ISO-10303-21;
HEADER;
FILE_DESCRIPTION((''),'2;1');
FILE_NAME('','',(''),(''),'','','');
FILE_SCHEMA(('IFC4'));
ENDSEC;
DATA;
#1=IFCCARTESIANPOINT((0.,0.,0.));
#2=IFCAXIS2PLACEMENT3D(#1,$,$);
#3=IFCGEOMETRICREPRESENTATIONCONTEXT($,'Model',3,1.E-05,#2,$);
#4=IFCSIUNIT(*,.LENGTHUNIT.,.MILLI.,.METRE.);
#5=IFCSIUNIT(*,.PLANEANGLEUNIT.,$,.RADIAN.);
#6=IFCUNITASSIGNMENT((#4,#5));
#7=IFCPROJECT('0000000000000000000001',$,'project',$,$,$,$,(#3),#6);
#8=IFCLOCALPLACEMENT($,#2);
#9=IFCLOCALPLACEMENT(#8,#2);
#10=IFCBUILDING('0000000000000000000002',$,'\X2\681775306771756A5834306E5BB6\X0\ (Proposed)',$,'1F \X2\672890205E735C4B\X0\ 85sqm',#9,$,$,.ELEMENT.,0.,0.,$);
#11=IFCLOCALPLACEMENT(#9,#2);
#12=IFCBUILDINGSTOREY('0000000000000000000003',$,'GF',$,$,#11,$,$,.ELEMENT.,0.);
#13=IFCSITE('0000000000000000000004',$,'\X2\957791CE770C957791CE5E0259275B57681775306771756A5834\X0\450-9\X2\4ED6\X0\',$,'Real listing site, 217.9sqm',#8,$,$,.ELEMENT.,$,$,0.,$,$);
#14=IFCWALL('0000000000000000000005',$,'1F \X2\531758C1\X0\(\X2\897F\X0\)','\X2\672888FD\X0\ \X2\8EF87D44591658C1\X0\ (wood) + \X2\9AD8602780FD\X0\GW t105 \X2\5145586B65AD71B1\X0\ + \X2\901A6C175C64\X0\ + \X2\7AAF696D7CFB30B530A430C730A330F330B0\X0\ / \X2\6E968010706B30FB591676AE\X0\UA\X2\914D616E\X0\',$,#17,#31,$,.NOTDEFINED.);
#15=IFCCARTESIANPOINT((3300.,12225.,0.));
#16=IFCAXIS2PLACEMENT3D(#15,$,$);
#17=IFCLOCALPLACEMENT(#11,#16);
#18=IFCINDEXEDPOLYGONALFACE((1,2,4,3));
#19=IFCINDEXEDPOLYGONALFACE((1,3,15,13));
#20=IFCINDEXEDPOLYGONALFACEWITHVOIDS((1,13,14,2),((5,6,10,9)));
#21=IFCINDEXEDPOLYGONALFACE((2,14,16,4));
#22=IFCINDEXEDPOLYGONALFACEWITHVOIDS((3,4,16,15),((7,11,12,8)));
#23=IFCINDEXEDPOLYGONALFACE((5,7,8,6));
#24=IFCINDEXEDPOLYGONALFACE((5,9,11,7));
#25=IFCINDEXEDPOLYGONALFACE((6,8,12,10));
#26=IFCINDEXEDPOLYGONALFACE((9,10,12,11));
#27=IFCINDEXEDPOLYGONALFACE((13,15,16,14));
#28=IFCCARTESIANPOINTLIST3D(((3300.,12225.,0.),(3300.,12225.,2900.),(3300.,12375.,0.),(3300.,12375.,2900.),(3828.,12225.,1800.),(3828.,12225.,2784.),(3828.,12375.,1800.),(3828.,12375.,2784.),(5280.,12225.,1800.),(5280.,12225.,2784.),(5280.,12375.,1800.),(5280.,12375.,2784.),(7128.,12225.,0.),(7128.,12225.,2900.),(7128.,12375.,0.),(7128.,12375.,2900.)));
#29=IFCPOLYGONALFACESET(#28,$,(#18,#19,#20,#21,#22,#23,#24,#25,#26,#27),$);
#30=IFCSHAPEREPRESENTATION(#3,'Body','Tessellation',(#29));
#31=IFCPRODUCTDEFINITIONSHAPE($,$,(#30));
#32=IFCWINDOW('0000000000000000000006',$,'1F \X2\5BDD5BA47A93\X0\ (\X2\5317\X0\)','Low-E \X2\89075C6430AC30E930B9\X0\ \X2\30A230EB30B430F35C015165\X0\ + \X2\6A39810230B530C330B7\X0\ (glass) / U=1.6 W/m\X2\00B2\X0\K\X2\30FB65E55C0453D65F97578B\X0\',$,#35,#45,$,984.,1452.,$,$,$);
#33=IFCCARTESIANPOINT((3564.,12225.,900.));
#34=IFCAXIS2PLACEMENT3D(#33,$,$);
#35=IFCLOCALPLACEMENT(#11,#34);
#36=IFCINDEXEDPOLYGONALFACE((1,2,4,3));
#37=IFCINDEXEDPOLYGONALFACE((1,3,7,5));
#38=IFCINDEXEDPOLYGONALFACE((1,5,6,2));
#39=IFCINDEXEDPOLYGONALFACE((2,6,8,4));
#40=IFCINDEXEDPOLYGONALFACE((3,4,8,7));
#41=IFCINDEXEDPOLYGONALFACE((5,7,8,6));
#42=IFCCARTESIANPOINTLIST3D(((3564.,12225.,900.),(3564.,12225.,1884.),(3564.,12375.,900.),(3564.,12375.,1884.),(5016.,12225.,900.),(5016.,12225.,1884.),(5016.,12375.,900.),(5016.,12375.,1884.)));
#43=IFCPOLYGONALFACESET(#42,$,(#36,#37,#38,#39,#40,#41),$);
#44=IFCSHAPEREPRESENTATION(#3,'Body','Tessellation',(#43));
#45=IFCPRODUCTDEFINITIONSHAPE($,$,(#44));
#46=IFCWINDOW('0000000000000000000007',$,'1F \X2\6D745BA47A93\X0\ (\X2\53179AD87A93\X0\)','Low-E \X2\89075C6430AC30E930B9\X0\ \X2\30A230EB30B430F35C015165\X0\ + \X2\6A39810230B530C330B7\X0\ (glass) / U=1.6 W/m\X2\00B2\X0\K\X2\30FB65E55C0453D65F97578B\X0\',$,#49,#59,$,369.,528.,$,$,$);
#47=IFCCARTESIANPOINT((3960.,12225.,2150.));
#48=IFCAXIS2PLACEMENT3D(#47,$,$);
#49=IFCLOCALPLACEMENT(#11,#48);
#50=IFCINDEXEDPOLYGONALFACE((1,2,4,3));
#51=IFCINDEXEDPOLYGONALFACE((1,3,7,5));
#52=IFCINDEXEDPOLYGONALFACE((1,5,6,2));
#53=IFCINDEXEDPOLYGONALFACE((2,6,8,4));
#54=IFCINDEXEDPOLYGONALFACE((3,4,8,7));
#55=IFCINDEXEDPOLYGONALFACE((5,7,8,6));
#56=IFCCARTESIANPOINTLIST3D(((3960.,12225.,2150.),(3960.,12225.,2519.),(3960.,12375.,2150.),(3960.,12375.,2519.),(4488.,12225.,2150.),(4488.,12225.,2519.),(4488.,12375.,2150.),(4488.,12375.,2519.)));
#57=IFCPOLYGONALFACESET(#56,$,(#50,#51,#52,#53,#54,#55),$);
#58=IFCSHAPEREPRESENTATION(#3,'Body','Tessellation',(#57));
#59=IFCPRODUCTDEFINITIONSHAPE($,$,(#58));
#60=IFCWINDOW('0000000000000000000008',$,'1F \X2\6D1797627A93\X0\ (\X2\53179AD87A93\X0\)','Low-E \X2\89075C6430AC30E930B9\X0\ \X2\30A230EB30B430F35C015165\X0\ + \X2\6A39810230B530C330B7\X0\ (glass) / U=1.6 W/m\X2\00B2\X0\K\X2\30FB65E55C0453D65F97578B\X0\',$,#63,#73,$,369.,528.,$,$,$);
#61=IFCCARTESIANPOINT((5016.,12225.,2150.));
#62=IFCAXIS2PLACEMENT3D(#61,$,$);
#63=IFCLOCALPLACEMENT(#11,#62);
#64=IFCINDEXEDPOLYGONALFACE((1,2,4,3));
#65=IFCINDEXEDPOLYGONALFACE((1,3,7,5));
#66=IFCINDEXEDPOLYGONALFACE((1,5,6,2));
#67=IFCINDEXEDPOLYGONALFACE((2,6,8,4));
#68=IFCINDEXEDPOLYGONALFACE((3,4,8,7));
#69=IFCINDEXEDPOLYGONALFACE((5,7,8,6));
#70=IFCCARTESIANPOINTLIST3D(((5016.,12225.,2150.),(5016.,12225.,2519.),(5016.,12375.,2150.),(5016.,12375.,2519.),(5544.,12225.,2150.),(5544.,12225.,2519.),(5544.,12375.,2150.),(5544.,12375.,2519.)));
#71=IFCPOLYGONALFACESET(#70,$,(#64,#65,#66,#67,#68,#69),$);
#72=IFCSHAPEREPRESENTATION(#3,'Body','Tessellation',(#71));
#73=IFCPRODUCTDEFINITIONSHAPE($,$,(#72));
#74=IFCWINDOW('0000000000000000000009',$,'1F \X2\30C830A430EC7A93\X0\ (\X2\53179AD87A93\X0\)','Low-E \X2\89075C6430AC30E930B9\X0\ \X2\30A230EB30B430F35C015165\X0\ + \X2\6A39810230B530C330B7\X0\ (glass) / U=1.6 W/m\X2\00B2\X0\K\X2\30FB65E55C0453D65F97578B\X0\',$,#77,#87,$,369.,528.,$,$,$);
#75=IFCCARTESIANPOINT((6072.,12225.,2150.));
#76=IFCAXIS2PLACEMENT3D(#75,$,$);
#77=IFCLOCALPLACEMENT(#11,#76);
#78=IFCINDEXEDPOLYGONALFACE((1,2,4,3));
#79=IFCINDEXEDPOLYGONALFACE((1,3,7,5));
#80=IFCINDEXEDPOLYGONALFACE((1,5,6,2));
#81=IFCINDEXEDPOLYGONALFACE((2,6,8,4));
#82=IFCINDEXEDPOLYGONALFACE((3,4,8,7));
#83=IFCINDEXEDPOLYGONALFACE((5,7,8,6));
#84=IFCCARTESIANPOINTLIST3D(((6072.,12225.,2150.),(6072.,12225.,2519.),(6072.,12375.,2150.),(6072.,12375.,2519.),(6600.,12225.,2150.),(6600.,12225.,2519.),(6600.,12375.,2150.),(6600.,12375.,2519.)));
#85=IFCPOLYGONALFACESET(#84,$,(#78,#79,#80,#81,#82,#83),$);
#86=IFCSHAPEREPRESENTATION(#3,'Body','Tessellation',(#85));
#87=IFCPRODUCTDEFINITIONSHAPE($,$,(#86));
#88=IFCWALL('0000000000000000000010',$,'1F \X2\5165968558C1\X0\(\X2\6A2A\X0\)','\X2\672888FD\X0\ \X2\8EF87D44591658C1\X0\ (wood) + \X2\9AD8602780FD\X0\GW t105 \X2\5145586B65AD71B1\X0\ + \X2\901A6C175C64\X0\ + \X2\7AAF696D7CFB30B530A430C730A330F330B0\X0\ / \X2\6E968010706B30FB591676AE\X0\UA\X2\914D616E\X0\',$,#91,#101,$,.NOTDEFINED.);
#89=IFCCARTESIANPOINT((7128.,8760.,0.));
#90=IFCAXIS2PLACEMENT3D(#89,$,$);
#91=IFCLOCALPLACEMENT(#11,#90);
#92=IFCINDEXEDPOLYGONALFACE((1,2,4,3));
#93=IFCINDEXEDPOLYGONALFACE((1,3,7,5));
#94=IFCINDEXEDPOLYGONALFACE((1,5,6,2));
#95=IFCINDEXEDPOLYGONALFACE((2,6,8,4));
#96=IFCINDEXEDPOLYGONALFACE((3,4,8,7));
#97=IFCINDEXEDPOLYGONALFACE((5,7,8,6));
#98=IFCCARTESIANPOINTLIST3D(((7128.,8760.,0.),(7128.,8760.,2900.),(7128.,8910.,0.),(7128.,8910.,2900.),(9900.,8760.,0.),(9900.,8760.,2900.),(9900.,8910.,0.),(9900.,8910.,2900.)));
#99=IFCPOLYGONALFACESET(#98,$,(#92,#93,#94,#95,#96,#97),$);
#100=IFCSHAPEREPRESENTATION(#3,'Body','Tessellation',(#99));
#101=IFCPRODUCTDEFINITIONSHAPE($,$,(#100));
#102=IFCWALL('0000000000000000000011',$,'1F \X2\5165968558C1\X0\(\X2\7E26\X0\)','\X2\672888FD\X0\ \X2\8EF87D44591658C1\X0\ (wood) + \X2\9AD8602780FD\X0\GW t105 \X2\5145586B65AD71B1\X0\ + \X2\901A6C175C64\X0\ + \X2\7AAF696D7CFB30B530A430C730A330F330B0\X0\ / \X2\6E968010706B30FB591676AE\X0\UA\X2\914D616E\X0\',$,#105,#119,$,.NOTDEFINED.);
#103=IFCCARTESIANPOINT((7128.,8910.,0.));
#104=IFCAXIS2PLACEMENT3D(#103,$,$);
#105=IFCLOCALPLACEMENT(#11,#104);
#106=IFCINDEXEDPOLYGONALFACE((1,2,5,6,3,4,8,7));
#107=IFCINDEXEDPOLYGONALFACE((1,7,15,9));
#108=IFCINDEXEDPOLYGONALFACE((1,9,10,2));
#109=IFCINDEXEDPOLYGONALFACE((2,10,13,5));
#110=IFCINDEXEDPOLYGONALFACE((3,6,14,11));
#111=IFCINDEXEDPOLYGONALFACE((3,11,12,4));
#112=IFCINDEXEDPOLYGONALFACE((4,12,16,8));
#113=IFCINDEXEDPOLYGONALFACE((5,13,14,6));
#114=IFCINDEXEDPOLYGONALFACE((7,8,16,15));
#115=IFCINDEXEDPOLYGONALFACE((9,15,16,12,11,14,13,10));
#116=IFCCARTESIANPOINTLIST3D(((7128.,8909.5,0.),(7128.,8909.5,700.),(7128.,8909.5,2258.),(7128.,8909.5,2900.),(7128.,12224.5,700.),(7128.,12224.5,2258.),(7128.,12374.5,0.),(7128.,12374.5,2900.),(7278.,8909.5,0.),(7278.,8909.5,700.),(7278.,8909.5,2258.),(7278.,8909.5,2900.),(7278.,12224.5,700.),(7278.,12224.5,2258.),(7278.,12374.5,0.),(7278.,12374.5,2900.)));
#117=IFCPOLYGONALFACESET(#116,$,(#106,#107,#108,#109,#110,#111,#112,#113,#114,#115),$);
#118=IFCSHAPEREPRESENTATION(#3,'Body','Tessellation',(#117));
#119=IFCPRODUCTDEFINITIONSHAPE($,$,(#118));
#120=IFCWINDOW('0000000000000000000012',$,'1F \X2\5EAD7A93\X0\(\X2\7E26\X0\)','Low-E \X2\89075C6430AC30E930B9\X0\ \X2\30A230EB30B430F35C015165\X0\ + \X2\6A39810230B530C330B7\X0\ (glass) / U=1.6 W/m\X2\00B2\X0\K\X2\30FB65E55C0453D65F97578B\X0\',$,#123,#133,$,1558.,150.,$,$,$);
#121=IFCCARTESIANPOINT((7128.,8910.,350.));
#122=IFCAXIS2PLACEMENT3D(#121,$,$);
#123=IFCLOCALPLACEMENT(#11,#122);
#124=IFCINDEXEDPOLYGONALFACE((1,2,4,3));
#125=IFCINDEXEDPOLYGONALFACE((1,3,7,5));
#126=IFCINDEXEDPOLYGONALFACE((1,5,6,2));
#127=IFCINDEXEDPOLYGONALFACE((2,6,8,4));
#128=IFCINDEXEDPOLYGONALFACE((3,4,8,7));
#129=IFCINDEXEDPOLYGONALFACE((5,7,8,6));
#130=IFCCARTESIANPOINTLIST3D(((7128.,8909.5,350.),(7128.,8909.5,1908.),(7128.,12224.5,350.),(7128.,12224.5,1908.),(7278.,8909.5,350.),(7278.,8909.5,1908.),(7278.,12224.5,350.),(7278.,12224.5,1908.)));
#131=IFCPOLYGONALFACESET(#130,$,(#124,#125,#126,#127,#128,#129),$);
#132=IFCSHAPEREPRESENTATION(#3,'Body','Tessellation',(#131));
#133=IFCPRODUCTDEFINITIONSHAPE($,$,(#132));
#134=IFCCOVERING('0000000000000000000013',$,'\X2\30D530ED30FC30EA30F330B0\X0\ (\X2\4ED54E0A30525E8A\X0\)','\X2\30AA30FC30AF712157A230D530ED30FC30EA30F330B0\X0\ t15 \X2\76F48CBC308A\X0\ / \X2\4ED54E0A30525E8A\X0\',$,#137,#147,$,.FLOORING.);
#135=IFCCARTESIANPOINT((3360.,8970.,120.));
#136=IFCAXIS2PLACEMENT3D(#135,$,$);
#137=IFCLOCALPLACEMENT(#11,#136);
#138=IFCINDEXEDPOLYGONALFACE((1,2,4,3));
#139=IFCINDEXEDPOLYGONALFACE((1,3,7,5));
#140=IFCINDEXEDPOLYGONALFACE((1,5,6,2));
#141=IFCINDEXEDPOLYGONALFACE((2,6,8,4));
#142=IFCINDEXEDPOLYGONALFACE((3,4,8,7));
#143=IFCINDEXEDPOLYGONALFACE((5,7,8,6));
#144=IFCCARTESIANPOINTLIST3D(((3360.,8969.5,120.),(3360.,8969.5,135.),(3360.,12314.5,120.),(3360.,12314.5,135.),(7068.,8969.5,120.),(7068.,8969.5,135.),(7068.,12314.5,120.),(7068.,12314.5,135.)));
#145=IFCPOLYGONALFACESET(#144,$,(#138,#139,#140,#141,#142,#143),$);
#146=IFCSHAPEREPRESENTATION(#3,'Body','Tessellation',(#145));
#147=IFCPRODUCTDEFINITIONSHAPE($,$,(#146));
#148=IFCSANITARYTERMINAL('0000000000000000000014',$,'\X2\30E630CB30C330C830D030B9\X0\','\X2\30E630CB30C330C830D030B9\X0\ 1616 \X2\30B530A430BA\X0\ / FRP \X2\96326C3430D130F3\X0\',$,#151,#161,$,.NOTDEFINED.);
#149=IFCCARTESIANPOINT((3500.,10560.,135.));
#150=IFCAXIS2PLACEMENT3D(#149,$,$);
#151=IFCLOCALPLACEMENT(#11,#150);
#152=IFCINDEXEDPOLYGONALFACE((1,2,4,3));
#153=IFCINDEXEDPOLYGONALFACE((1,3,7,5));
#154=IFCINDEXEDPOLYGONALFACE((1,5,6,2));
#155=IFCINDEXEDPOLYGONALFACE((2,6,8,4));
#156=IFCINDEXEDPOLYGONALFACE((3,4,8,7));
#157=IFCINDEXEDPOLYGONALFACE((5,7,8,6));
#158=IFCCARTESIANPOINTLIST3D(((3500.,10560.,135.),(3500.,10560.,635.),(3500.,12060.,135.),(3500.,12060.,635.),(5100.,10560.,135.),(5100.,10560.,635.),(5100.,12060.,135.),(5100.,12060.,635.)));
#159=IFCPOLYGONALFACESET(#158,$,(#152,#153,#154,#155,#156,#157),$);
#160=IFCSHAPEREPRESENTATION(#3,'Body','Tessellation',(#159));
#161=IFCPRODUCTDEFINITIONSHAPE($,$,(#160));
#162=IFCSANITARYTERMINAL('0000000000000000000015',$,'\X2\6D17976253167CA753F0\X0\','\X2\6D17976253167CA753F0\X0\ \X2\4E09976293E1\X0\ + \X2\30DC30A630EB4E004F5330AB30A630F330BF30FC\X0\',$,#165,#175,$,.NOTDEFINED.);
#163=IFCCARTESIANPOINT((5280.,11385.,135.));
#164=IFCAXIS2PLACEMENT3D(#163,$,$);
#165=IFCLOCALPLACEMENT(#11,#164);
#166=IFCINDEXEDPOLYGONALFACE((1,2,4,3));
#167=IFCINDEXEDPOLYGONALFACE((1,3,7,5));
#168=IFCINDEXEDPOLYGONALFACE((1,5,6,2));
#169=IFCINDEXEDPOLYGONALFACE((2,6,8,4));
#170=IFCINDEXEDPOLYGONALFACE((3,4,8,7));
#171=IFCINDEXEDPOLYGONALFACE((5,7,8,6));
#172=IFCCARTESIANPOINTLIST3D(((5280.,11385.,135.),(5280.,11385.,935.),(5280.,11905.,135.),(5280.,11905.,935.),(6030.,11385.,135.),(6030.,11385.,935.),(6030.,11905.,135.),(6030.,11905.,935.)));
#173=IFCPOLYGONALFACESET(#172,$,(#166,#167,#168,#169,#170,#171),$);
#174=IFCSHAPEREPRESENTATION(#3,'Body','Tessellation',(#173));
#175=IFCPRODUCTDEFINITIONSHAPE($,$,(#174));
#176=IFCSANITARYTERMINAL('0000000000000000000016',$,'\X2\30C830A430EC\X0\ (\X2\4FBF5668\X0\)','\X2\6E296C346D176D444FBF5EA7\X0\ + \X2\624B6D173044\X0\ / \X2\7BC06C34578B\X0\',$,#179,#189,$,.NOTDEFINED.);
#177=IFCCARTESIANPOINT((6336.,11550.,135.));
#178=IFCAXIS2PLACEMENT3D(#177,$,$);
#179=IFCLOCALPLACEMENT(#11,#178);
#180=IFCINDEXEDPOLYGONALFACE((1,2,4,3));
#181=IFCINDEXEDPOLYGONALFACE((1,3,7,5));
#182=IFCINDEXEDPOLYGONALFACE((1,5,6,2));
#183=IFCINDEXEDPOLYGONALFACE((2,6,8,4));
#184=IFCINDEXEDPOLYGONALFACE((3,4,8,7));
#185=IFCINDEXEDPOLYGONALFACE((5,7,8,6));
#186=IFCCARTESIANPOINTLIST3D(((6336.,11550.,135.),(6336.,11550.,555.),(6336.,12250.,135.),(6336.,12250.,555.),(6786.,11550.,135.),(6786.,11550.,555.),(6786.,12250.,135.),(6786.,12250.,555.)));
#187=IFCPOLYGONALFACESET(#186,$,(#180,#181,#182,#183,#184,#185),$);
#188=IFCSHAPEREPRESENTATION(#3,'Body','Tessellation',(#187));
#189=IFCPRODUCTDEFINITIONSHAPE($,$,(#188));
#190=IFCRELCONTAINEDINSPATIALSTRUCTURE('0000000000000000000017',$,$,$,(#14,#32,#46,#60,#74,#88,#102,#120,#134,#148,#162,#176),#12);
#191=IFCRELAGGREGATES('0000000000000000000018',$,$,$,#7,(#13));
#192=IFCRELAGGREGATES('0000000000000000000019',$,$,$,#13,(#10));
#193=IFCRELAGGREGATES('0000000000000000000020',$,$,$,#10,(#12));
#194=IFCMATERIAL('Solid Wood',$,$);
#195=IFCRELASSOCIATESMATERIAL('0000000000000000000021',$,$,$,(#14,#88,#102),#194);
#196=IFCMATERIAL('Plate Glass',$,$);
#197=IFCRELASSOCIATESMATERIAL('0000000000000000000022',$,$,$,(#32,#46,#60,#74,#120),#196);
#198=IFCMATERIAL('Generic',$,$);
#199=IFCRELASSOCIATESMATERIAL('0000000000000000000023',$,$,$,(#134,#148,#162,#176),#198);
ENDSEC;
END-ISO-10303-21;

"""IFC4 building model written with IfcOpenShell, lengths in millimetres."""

from ifc_helpers import new_model, si_unit, frame, frame_2d, origin, place, context, project, spatial, rectangle, extrude, material, element, fill, save


model = new_model("IFC4")

# Units and contexts
model_context = context("Model", 3, precision=1e-05, world=origin())
ifc_project = project(units=[si_unit("LENGTHUNIT", "METRE", prefix="MILLI"), si_unit("PLANEANGLEUNIT", "RADIAN")], contexts=[model_context])

# Site, building, storey
site_placement = place(None, origin())
site = spatial("IfcSite", under=ifc_project, at=site_placement, Name="長野県長野市大字栗田東番場450-9他", ObjectType="Real listing site, 217.9sqm", CompositionType="ELEMENT", RefElevation=0.0)
building_placement = place(site_placement, origin())
building = spatial("IfcBuilding", under=site, at=building_placement, Name="栗田東番場の家 (Proposed)", ObjectType="1F 木造平屋 85sqm", CompositionType="ELEMENT", ElevationOfRefHeight=0.0, ElevationOfTerrain=0.0)
storey_placement = place(building_placement, origin())
storey = spatial("IfcBuildingStorey", under=building, at=storey_placement, Name="GF", CompositionType="ELEMENT", Elevation=0.0)

# Shared definitions
ifc_material_1 = material(Name="Solid Wood")

# Wall, openings, windows
wall_1_placement = place(storey_placement, frame((3300.0, 12225.0, 0.0)))
wall_1 = element("IfcWall", 1, at=wall_1_placement, inside=storey, material=ifc_material_1, Name="1F 北壁(西)", Description="木製 軸組外壁 (wood) + 高性能GW t105 充填断熱 + 通気層 + 窯業系サイディング / 準耐火・外皮UA配慮", PredefinedType="NOTDEFINED", context=model_context, shape_type="SweptSolid", body=[
    extrude(rectangle(XDim=3828.0, YDim=150.0, at=frame_2d((1914.0, 75.0))), frame((3300.0, 12225.0, 0.0)), (0.0, 0.0, 1.0), 2900.0),
])
opening_1_placement = place(storey_placement, frame((3564.0, 12225.0, 900.0)))
opening_1 = element("IfcOpeningElement", 2, at=opening_1_placement, cuts=wall_1, PredefinedType="NOTDEFINED", context=model_context, shape_type="SweptSolid", body=[
    extrude(rectangle(XDim=1452.0, YDim=150.0, at=frame_2d((726.0, 75.0))), frame((3564.0, 12225.0, 900.0)), (0.0, 0.0, 1.0), 984.0),
])
opening_2_placement = place(storey_placement, frame((3960.0, 12225.0, 2150.0)))
opening_2 = element("IfcOpeningElement", 3, at=opening_2_placement, cuts=wall_1, PredefinedType="NOTDEFINED", context=model_context, shape_type="SweptSolid", body=[
    extrude(rectangle(XDim=528.0, YDim=150.0, at=frame_2d((264.0, 75.0))), frame((3960.0, 12225.0, 2150.0)), (0.0, 0.0, 1.0), 369.0),
])
opening_3_placement = place(storey_placement, frame((5016.0, 12225.0, 2150.0)))
opening_3 = element("IfcOpeningElement", 4, at=opening_3_placement, cuts=wall_1, PredefinedType="NOTDEFINED", context=model_context, shape_type="SweptSolid", body=[
    extrude(rectangle(XDim=528.0, YDim=150.0, at=frame_2d((264.0, 75.0))), frame((5016.0, 12225.0, 2150.0)), (0.0, 0.0, 1.0), 369.0),
])
opening_4_placement = place(storey_placement, frame((6072.0, 12225.0, 2150.0)))
opening_4 = element("IfcOpeningElement", 5, at=opening_4_placement, cuts=wall_1, PredefinedType="NOTDEFINED", context=model_context, shape_type="SweptSolid", body=[
    extrude(rectangle(XDim=528.0, YDim=150.0, at=frame_2d((264.0, 75.0))), frame((6072.0, 12225.0, 2150.0)), (0.0, 0.0, 1.0), 369.0),
])
ifc_material_2 = material(Name="Plate Glass")
window_1_placement = place(storey_placement, frame((3564.0, 12225.0, 900.0)))
window_1 = element("IfcWindow", 6, at=window_1_placement, inside=storey, material=ifc_material_2, Name="1F 寝室窓 (北)", Description="Low-E 複層ガラス アルゴン封入 + 樹脂サッシ (glass) / U=1.6 W/m²K・日射取得型", OverallHeight=984.0, OverallWidth=1452.0, context=model_context, shape_type="SweptSolid", body=[
    extrude(rectangle(XDim=1452.0, YDim=150.0, at=frame_2d((726.0, 75.0))), frame((3564.0, 12225.0, 900.0)), (0.0, 0.0, 1.0), 984.0),
])
fill(opening_1, window_1)
window_2_placement = place(storey_placement, frame((3960.0, 12225.0, 2150.0)))
window_2 = element("IfcWindow", 7, at=window_2_placement, inside=storey, material=ifc_material_2, Name="1F 浴室窓 (北高窓)", Description="Low-E 複層ガラス アルゴン封入 + 樹脂サッシ (glass) / U=1.6 W/m²K・日射取得型", OverallHeight=369.0, OverallWidth=528.0, context=model_context, shape_type="SweptSolid", body=[
    extrude(rectangle(XDim=528.0, YDim=150.0, at=frame_2d((264.0, 75.0))), frame((3960.0, 12225.0, 2150.0)), (0.0, 0.0, 1.0), 369.0),
])
fill(opening_2, window_2)
window_3_placement = place(storey_placement, frame((5016.0, 12225.0, 2150.0)))
window_3 = element("IfcWindow", 8, at=window_3_placement, inside=storey, material=ifc_material_2, Name="1F 洗面窓 (北高窓)", Description="Low-E 複層ガラス アルゴン封入 + 樹脂サッシ (glass) / U=1.6 W/m²K・日射取得型", OverallHeight=369.0, OverallWidth=528.0, context=model_context, shape_type="SweptSolid", body=[
    extrude(rectangle(XDim=528.0, YDim=150.0, at=frame_2d((264.0, 75.0))), frame((5016.0, 12225.0, 2150.0)), (0.0, 0.0, 1.0), 369.0),
])
fill(opening_3, window_3)
window_4_placement = place(storey_placement, frame((6072.0, 12225.0, 2150.0)))
window_4 = element("IfcWindow", 9, at=window_4_placement, inside=storey, material=ifc_material_2, Name="1F トイレ窓 (北高窓)", Description="Low-E 複層ガラス アルゴン封入 + 樹脂サッシ (glass) / U=1.6 W/m²K・日射取得型", OverallHeight=369.0, OverallWidth=528.0, context=model_context, shape_type="SweptSolid", body=[
    extrude(rectangle(XDim=528.0, YDim=150.0, at=frame_2d((264.0, 75.0))), frame((6072.0, 12225.0, 2150.0)), (0.0, 0.0, 1.0), 369.0),
])
fill(opening_4, window_4)

# Wall
wall_2_placement = place(storey_placement, frame((7128.0, 8760.0, 0.0)))
element("IfcWall", 10, at=wall_2_placement, inside=storey, material=ifc_material_1, Name="1F 入隅壁(横)", Description="木製 軸組外壁 (wood) + 高性能GW t105 充填断熱 + 通気層 + 窯業系サイディング / 準耐火・外皮UA配慮", PredefinedType="NOTDEFINED", context=model_context, shape_type="SweptSolid", body=[
    extrude(rectangle(XDim=2772.0, YDim=150.0, at=frame_2d((1386.0, 75.0))), frame((7128.0, 8760.0, 0.0)), (0.0, 0.0, 1.0), 2900.0),
])

# Wall, opening, window
wall_3_placement = place(storey_placement, frame((7128.0, 8910.0, 0.0)))
wall_3 = element("IfcWall", 11, at=wall_3_placement, inside=storey, material=ifc_material_1, Name="1F 入隅壁(縦)", Description="木製 軸組外壁 (wood) + 高性能GW t105 充填断熱 + 通気層 + 窯業系サイディング / 準耐火・外皮UA配慮", PredefinedType="NOTDEFINED", context=model_context, shape_type="SweptSolid", body=[
    extrude(rectangle(XDim=150.0, YDim=3465.0, at=frame_2d((75.0, 1732.0))), frame((7128.0, 8910.0, 0.0)), (0.0, 0.0, 1.0), 2900.0),
])
opening_5_placement = place(storey_placement, frame((7128.0, 8910.0, 350.0)))
opening_5 = element("IfcOpeningElement", 12, at=opening_5_placement, cuts=wall_3, PredefinedType="NOTDEFINED", context=model_context, shape_type="SweptSolid", body=[
    extrude(rectangle(XDim=150.0, YDim=3315.0, at=frame_2d((75.0, 1657.0))), frame((7128.0, 8910.0, 350.0)), (0.0, 0.0, 1.0), 1558.0),
])
window_5_placement = place(storey_placement, frame((7128.0, 8910.0, 350.0)))
window_5 = element("IfcWindow", 13, at=window_5_placement, inside=storey, material=ifc_material_2, Name="1F 庭窓(縦)", Description="Low-E 複層ガラス アルゴン封入 + 樹脂サッシ (glass) / U=1.6 W/m²K・日射取得型", OverallHeight=1558.0, OverallWidth=150.0, context=model_context, shape_type="SweptSolid", body=[
    extrude(rectangle(XDim=150.0, YDim=3315.0, at=frame_2d((75.0, 1657.0))), frame((7128.0, 8910.0, 350.0)), (0.0, 0.0, 1.0), 1558.0),
])
fill(opening_5, window_5)

# Covering
ifc_material_3 = material(Name="Generic")
covering_placement = place(storey_placement, frame((3360.0, 8970.0, 120.0)))
element("IfcCovering", 14, at=covering_placement, inside=storey, material=ifc_material_3, Name="フローリング (仕上げ床)", Description="オーク無垢フローリング t15 直貼り / 仕上げ床", PredefinedType="FLOORING", context=model_context, shape_type="SweptSolid", body=[
    extrude(rectangle(XDim=3708.0, YDim=3345.0, at=frame_2d((1854.0, 1672.0))), frame((3360.0, 8970.0, 120.0)), (0.0, 0.0, 1.0), 15.0),
])

# Sanitary terminals
sanitary_terminal_1_placement = place(storey_placement, frame((3500.0, 10560.0, 135.0)))
element("IfcSanitaryTerminal", 15, at=sanitary_terminal_1_placement, inside=storey, material=ifc_material_3, Name="ユニットバス", Description="ユニットバス 1616 サイズ / FRP 防水パン", PredefinedType="NOTDEFINED", context=model_context, shape_type="SweptSolid", body=[
    extrude(rectangle(XDim=1600.0, YDim=1500.0, at=frame_2d((800.0, 750.0))), frame((3500.0, 10560.0, 135.0)), (0.0, 0.0, 1.0), 500.0),
])
sanitary_terminal_2_placement = place(storey_placement, frame((5280.0, 11385.0, 135.0)))
element("IfcSanitaryTerminal", 16, at=sanitary_terminal_2_placement, inside=storey, material=ifc_material_3, Name="洗面化粧台", Description="洗面化粧台 三面鏡 + ボウル一体カウンター", PredefinedType="NOTDEFINED", context=model_context, shape_type="SweptSolid", body=[
    extrude(rectangle(XDim=750.0, YDim=520.0, at=frame_2d((375.0, 260.0))), frame((5280.0, 11385.0, 135.0)), (0.0, 0.0, 1.0), 800.0),
])
sanitary_terminal_3_placement = place(storey_placement, frame((6336.0, 11550.0, 135.0)))
element("IfcSanitaryTerminal", 17, at=sanitary_terminal_3_placement, inside=storey, material=ifc_material_3, Name="トイレ (便器)", Description="温水洗浄便座 + 手洗い / 節水型", PredefinedType="NOTDEFINED", context=model_context, shape_type="SweptSolid", body=[
    extrude(rectangle(XDim=450.0, YDim=700.0, at=frame_2d((225.0, 350.0))), frame((6336.0, 11550.0, 135.0)), (0.0, 0.0, 1.0), 420.0),
])

save(model, "model.ifc")
